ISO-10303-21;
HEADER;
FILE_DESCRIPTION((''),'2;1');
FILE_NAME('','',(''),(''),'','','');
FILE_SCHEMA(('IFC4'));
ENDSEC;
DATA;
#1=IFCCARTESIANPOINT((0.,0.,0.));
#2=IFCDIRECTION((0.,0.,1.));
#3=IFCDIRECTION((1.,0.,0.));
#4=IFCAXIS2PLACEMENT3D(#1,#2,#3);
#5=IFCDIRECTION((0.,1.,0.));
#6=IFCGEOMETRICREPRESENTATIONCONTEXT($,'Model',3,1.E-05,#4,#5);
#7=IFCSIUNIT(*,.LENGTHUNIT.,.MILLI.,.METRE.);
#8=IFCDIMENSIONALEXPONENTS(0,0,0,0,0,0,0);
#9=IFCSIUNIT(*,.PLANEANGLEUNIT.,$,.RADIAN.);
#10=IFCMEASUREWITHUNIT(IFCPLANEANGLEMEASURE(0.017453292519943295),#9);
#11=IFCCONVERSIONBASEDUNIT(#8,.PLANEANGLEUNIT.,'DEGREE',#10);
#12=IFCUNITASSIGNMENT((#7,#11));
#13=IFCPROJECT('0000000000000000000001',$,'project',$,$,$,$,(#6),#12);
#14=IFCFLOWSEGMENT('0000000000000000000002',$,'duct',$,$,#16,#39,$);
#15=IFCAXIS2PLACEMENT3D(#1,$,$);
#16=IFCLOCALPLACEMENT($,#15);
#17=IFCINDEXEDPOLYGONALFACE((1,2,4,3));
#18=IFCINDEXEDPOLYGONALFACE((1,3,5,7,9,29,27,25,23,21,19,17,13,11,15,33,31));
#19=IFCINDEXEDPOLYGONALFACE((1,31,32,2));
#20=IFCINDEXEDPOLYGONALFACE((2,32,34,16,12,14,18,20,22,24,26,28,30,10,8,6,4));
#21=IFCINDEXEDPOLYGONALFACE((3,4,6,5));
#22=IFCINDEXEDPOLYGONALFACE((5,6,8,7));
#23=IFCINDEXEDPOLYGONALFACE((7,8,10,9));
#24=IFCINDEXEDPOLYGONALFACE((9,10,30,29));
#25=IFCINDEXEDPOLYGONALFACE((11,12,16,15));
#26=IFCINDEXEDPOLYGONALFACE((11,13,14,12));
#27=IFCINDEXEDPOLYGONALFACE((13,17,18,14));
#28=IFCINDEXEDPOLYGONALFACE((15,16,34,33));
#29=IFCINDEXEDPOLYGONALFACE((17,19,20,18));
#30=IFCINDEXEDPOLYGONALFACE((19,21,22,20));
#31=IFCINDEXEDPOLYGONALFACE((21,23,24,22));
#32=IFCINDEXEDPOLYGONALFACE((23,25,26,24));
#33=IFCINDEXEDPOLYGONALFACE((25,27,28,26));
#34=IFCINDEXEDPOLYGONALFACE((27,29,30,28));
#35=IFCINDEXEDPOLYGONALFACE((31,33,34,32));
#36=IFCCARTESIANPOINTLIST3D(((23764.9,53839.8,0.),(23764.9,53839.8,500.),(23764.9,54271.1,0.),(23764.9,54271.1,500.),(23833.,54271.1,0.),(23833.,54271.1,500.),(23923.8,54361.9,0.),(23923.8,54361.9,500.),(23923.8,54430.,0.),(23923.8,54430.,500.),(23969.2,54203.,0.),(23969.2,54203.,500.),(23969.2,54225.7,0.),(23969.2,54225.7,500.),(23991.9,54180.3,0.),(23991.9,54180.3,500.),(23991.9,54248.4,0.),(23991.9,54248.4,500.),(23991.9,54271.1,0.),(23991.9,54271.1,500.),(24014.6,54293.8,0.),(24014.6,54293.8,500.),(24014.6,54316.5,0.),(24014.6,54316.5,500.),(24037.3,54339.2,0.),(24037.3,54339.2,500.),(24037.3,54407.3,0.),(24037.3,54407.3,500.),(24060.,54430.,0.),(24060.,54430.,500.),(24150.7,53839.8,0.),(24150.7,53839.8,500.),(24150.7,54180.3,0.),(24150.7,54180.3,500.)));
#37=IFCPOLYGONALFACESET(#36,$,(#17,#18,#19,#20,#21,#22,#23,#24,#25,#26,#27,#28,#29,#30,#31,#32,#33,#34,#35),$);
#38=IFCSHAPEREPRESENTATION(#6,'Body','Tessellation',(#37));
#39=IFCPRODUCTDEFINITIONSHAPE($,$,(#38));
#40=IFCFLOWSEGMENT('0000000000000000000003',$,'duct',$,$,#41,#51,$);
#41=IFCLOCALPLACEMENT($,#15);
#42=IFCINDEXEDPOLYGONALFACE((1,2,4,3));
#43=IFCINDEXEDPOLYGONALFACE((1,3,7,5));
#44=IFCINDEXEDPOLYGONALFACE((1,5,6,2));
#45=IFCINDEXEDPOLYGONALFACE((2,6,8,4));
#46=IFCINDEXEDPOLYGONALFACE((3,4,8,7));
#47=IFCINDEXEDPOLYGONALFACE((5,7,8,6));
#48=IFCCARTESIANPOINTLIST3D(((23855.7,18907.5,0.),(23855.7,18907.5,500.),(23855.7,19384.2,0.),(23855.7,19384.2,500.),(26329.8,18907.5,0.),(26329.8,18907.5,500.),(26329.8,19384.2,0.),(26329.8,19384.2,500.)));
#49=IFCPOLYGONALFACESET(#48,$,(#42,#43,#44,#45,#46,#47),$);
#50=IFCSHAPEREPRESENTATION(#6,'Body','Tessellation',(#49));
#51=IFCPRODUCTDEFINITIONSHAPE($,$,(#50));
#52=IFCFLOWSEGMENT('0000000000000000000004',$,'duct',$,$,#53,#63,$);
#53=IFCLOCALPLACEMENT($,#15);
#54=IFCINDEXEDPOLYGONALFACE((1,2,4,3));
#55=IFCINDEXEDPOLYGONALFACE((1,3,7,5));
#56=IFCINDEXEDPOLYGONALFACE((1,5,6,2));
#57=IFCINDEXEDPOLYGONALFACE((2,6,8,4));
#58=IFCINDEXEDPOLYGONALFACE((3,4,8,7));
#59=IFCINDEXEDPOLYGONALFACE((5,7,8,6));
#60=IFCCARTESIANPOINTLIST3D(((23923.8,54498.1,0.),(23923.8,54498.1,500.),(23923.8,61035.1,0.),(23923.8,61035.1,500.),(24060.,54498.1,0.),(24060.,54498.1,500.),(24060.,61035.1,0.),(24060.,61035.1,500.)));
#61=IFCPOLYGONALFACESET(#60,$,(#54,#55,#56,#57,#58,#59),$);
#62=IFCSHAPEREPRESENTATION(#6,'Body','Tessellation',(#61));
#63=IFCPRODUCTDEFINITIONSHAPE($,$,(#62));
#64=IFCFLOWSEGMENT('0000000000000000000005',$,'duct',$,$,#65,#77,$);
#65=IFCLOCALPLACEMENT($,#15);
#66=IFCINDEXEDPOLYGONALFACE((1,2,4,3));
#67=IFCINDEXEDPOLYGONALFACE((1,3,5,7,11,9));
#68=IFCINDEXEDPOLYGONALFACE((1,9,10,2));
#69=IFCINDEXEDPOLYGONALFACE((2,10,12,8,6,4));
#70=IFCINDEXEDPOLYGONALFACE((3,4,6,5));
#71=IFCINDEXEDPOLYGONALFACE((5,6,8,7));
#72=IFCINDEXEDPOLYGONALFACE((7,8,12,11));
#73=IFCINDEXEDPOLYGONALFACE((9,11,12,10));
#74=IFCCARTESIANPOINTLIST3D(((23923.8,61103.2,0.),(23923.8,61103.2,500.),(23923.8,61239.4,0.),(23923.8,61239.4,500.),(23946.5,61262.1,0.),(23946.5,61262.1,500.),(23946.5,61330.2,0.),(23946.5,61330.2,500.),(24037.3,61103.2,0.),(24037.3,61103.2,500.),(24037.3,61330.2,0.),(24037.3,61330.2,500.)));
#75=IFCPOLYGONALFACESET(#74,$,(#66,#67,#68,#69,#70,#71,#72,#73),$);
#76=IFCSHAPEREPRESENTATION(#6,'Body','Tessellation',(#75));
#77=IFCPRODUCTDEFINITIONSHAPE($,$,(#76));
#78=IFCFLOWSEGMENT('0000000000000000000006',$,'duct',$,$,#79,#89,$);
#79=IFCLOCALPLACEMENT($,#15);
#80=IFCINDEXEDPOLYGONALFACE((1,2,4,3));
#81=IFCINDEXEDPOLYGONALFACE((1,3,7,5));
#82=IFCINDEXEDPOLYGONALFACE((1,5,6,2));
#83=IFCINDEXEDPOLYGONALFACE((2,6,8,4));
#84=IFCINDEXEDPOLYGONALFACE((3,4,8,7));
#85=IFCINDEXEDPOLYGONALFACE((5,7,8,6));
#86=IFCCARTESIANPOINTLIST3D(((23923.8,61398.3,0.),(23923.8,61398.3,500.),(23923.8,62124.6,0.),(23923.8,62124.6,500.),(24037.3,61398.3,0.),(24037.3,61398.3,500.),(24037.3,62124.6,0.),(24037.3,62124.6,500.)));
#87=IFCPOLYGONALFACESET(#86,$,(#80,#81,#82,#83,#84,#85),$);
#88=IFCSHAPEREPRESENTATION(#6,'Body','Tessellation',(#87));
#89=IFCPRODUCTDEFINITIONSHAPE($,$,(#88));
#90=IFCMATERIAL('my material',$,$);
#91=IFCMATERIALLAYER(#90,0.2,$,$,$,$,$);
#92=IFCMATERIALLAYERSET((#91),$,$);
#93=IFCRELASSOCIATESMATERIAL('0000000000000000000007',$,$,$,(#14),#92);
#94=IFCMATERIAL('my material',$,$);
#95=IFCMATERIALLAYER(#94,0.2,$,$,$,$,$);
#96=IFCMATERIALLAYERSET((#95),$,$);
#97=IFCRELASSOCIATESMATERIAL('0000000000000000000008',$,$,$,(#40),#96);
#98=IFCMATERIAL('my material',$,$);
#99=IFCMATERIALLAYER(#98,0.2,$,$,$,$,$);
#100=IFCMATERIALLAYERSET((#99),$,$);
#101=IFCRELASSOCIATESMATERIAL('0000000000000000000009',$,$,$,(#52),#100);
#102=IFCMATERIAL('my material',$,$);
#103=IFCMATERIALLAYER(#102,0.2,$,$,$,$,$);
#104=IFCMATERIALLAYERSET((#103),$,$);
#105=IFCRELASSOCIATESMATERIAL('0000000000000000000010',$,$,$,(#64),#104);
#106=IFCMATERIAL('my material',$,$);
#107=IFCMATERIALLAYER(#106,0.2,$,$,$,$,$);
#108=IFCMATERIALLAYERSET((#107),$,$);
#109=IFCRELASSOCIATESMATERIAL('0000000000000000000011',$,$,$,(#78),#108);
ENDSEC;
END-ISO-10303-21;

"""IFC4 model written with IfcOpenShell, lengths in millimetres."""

from ifc_helpers import new_model, entity, si_unit, converted_unit, direction, origin_with_axes, place, context, project, polyline, outline, extrude, material, layer, layer_set, layer_usage, element, save


model = new_model("IFC4")

# Units and contexts
model_context = context("Model", 3, precision=1e-05, world=origin_with_axes(), true_north=direction((0.0, 1.0, 0.0)))
ifc_project = project(units=[si_unit("LENGTHUNIT", "METRE", prefix="MILLI"), converted_unit("PLANEANGLEUNIT", "DEGREE", entity("IfcPlaneAngleMeasure", 0.017453292519943295), si_unit("PLANEANGLEUNIT", "RADIAN"), dimensions=[0, 0, 0, 0, 0, 0, 0])], contexts=[model_context])

# Flow segments
ifc_material_1 = material(Name="my material")
ifc_layer_1 = layer(ifc_material_1, 0.2)
ifc_layer_set_1 = layer_set([ifc_layer_1])
ifc_layer_usage_1 = layer_usage(ifc_layer_set_1, "AXIS2", "POSITIVE", -0.1)
flow_segment_1_placement = place(None, origin_with_axes())
element("IfcFlowSegment", 1, at=flow_segment_1_placement, material=ifc_layer_usage_1, Name="duct", context=model_context, shape_type="SweptSolid", body=[
    extrude(outline(polyline([(23764.9, 53839.8), (24150.7, 53839.8), (24150.7, 54180.3), (23991.9, 54180.3), (23969.2, 54203.0), (23969.2, 54225.7), (23991.9, 54248.4), (23991.9, 54271.1), (24014.6, 54293.8), (24014.6, 54316.5), (24037.3, 54339.2), (24037.3, 54407.3), (24060.0, 54430.0), (23923.8, 54430.0), (23923.8, 54361.9), (23833.0, 54271.1), (23764.9, 54271.1), (23764.9, 53839.8)])), origin_with_axes(), (0.0, 0.0, 1.0), 500.0),
])
ifc_material_2 = material(Name="my material")
ifc_layer_2 = layer(ifc_material_2, 0.2)
ifc_layer_set_2 = layer_set([ifc_layer_2])
ifc_layer_usage_2 = layer_usage(ifc_layer_set_2, "AXIS2", "POSITIVE", -0.1)
flow_segment_2_placement = place(None, origin_with_axes())
element("IfcFlowSegment", 2, at=flow_segment_2_placement, material=ifc_layer_usage_2, Name="duct", context=model_context, shape_type="SweptSolid", body=[
    extrude(outline(polyline([(23855.7, 18907.5), (26329.8, 18907.5), (26329.8, 19384.2), (23855.7, 19384.2), (23855.7, 18907.5)])), origin_with_axes(), (0.0, 0.0, 1.0), 500.0),
])
ifc_material_3 = material(Name="my material")
ifc_layer_3 = layer(ifc_material_3, 0.2)
ifc_layer_set_3 = layer_set([ifc_layer_3])
ifc_layer_usage_3 = layer_usage(ifc_layer_set_3, "AXIS2", "POSITIVE", -0.1)
flow_segment_3_placement = place(None, origin_with_axes())
element("IfcFlowSegment", 3, at=flow_segment_3_placement, material=ifc_layer_usage_3, Name="duct", context=model_context, shape_type="SweptSolid", body=[
    extrude(outline(polyline([(23923.8, 54498.1), (24060.0, 54498.1), (24060.0, 61035.1), (23923.8, 61035.1), (23923.8, 54498.1)])), origin_with_axes(), (0.0, 0.0, 1.0), 500.0),
])
ifc_material_4 = material(Name="my material")
ifc_layer_4 = layer(ifc_material_4, 0.2)
ifc_layer_set_4 = layer_set([ifc_layer_4])
ifc_layer_usage_4 = layer_usage(ifc_layer_set_4, "AXIS2", "POSITIVE", -0.1)
flow_segment_4_placement = place(None, origin_with_axes())
element("IfcFlowSegment", 4, at=flow_segment_4_placement, material=ifc_layer_usage_4, Name="duct", context=model_context, shape_type="SweptSolid", body=[
    extrude(outline(polyline([(23923.8, 61103.2), (24037.3, 61103.2), (24037.3, 61330.2), (23946.5, 61330.2), (23946.5, 61262.1), (23923.8, 61239.4), (23923.8, 61103.2)])), origin_with_axes(), (0.0, 0.0, 1.0), 500.0),
])
ifc_material_5 = material(Name="my material")
ifc_layer_5 = layer(ifc_material_5, 0.2)
ifc_layer_set_5 = layer_set([ifc_layer_5])
ifc_layer_usage_5 = layer_usage(ifc_layer_set_5, "AXIS2", "POSITIVE", -0.1)
flow_segment_5_placement = place(None, origin_with_axes())
element("IfcFlowSegment", 5, at=flow_segment_5_placement, material=ifc_layer_usage_5, Name="duct", context=model_context, shape_type="SweptSolid", body=[
    extrude(outline(polyline([(23923.8, 61398.3), (24037.3, 61398.3), (24037.3, 62124.6), (23923.8, 62124.6), (23923.8, 61398.3)])), origin_with_axes(), (0.0, 0.0, 1.0), 500.0),
])

save(model, "model.ifc")
